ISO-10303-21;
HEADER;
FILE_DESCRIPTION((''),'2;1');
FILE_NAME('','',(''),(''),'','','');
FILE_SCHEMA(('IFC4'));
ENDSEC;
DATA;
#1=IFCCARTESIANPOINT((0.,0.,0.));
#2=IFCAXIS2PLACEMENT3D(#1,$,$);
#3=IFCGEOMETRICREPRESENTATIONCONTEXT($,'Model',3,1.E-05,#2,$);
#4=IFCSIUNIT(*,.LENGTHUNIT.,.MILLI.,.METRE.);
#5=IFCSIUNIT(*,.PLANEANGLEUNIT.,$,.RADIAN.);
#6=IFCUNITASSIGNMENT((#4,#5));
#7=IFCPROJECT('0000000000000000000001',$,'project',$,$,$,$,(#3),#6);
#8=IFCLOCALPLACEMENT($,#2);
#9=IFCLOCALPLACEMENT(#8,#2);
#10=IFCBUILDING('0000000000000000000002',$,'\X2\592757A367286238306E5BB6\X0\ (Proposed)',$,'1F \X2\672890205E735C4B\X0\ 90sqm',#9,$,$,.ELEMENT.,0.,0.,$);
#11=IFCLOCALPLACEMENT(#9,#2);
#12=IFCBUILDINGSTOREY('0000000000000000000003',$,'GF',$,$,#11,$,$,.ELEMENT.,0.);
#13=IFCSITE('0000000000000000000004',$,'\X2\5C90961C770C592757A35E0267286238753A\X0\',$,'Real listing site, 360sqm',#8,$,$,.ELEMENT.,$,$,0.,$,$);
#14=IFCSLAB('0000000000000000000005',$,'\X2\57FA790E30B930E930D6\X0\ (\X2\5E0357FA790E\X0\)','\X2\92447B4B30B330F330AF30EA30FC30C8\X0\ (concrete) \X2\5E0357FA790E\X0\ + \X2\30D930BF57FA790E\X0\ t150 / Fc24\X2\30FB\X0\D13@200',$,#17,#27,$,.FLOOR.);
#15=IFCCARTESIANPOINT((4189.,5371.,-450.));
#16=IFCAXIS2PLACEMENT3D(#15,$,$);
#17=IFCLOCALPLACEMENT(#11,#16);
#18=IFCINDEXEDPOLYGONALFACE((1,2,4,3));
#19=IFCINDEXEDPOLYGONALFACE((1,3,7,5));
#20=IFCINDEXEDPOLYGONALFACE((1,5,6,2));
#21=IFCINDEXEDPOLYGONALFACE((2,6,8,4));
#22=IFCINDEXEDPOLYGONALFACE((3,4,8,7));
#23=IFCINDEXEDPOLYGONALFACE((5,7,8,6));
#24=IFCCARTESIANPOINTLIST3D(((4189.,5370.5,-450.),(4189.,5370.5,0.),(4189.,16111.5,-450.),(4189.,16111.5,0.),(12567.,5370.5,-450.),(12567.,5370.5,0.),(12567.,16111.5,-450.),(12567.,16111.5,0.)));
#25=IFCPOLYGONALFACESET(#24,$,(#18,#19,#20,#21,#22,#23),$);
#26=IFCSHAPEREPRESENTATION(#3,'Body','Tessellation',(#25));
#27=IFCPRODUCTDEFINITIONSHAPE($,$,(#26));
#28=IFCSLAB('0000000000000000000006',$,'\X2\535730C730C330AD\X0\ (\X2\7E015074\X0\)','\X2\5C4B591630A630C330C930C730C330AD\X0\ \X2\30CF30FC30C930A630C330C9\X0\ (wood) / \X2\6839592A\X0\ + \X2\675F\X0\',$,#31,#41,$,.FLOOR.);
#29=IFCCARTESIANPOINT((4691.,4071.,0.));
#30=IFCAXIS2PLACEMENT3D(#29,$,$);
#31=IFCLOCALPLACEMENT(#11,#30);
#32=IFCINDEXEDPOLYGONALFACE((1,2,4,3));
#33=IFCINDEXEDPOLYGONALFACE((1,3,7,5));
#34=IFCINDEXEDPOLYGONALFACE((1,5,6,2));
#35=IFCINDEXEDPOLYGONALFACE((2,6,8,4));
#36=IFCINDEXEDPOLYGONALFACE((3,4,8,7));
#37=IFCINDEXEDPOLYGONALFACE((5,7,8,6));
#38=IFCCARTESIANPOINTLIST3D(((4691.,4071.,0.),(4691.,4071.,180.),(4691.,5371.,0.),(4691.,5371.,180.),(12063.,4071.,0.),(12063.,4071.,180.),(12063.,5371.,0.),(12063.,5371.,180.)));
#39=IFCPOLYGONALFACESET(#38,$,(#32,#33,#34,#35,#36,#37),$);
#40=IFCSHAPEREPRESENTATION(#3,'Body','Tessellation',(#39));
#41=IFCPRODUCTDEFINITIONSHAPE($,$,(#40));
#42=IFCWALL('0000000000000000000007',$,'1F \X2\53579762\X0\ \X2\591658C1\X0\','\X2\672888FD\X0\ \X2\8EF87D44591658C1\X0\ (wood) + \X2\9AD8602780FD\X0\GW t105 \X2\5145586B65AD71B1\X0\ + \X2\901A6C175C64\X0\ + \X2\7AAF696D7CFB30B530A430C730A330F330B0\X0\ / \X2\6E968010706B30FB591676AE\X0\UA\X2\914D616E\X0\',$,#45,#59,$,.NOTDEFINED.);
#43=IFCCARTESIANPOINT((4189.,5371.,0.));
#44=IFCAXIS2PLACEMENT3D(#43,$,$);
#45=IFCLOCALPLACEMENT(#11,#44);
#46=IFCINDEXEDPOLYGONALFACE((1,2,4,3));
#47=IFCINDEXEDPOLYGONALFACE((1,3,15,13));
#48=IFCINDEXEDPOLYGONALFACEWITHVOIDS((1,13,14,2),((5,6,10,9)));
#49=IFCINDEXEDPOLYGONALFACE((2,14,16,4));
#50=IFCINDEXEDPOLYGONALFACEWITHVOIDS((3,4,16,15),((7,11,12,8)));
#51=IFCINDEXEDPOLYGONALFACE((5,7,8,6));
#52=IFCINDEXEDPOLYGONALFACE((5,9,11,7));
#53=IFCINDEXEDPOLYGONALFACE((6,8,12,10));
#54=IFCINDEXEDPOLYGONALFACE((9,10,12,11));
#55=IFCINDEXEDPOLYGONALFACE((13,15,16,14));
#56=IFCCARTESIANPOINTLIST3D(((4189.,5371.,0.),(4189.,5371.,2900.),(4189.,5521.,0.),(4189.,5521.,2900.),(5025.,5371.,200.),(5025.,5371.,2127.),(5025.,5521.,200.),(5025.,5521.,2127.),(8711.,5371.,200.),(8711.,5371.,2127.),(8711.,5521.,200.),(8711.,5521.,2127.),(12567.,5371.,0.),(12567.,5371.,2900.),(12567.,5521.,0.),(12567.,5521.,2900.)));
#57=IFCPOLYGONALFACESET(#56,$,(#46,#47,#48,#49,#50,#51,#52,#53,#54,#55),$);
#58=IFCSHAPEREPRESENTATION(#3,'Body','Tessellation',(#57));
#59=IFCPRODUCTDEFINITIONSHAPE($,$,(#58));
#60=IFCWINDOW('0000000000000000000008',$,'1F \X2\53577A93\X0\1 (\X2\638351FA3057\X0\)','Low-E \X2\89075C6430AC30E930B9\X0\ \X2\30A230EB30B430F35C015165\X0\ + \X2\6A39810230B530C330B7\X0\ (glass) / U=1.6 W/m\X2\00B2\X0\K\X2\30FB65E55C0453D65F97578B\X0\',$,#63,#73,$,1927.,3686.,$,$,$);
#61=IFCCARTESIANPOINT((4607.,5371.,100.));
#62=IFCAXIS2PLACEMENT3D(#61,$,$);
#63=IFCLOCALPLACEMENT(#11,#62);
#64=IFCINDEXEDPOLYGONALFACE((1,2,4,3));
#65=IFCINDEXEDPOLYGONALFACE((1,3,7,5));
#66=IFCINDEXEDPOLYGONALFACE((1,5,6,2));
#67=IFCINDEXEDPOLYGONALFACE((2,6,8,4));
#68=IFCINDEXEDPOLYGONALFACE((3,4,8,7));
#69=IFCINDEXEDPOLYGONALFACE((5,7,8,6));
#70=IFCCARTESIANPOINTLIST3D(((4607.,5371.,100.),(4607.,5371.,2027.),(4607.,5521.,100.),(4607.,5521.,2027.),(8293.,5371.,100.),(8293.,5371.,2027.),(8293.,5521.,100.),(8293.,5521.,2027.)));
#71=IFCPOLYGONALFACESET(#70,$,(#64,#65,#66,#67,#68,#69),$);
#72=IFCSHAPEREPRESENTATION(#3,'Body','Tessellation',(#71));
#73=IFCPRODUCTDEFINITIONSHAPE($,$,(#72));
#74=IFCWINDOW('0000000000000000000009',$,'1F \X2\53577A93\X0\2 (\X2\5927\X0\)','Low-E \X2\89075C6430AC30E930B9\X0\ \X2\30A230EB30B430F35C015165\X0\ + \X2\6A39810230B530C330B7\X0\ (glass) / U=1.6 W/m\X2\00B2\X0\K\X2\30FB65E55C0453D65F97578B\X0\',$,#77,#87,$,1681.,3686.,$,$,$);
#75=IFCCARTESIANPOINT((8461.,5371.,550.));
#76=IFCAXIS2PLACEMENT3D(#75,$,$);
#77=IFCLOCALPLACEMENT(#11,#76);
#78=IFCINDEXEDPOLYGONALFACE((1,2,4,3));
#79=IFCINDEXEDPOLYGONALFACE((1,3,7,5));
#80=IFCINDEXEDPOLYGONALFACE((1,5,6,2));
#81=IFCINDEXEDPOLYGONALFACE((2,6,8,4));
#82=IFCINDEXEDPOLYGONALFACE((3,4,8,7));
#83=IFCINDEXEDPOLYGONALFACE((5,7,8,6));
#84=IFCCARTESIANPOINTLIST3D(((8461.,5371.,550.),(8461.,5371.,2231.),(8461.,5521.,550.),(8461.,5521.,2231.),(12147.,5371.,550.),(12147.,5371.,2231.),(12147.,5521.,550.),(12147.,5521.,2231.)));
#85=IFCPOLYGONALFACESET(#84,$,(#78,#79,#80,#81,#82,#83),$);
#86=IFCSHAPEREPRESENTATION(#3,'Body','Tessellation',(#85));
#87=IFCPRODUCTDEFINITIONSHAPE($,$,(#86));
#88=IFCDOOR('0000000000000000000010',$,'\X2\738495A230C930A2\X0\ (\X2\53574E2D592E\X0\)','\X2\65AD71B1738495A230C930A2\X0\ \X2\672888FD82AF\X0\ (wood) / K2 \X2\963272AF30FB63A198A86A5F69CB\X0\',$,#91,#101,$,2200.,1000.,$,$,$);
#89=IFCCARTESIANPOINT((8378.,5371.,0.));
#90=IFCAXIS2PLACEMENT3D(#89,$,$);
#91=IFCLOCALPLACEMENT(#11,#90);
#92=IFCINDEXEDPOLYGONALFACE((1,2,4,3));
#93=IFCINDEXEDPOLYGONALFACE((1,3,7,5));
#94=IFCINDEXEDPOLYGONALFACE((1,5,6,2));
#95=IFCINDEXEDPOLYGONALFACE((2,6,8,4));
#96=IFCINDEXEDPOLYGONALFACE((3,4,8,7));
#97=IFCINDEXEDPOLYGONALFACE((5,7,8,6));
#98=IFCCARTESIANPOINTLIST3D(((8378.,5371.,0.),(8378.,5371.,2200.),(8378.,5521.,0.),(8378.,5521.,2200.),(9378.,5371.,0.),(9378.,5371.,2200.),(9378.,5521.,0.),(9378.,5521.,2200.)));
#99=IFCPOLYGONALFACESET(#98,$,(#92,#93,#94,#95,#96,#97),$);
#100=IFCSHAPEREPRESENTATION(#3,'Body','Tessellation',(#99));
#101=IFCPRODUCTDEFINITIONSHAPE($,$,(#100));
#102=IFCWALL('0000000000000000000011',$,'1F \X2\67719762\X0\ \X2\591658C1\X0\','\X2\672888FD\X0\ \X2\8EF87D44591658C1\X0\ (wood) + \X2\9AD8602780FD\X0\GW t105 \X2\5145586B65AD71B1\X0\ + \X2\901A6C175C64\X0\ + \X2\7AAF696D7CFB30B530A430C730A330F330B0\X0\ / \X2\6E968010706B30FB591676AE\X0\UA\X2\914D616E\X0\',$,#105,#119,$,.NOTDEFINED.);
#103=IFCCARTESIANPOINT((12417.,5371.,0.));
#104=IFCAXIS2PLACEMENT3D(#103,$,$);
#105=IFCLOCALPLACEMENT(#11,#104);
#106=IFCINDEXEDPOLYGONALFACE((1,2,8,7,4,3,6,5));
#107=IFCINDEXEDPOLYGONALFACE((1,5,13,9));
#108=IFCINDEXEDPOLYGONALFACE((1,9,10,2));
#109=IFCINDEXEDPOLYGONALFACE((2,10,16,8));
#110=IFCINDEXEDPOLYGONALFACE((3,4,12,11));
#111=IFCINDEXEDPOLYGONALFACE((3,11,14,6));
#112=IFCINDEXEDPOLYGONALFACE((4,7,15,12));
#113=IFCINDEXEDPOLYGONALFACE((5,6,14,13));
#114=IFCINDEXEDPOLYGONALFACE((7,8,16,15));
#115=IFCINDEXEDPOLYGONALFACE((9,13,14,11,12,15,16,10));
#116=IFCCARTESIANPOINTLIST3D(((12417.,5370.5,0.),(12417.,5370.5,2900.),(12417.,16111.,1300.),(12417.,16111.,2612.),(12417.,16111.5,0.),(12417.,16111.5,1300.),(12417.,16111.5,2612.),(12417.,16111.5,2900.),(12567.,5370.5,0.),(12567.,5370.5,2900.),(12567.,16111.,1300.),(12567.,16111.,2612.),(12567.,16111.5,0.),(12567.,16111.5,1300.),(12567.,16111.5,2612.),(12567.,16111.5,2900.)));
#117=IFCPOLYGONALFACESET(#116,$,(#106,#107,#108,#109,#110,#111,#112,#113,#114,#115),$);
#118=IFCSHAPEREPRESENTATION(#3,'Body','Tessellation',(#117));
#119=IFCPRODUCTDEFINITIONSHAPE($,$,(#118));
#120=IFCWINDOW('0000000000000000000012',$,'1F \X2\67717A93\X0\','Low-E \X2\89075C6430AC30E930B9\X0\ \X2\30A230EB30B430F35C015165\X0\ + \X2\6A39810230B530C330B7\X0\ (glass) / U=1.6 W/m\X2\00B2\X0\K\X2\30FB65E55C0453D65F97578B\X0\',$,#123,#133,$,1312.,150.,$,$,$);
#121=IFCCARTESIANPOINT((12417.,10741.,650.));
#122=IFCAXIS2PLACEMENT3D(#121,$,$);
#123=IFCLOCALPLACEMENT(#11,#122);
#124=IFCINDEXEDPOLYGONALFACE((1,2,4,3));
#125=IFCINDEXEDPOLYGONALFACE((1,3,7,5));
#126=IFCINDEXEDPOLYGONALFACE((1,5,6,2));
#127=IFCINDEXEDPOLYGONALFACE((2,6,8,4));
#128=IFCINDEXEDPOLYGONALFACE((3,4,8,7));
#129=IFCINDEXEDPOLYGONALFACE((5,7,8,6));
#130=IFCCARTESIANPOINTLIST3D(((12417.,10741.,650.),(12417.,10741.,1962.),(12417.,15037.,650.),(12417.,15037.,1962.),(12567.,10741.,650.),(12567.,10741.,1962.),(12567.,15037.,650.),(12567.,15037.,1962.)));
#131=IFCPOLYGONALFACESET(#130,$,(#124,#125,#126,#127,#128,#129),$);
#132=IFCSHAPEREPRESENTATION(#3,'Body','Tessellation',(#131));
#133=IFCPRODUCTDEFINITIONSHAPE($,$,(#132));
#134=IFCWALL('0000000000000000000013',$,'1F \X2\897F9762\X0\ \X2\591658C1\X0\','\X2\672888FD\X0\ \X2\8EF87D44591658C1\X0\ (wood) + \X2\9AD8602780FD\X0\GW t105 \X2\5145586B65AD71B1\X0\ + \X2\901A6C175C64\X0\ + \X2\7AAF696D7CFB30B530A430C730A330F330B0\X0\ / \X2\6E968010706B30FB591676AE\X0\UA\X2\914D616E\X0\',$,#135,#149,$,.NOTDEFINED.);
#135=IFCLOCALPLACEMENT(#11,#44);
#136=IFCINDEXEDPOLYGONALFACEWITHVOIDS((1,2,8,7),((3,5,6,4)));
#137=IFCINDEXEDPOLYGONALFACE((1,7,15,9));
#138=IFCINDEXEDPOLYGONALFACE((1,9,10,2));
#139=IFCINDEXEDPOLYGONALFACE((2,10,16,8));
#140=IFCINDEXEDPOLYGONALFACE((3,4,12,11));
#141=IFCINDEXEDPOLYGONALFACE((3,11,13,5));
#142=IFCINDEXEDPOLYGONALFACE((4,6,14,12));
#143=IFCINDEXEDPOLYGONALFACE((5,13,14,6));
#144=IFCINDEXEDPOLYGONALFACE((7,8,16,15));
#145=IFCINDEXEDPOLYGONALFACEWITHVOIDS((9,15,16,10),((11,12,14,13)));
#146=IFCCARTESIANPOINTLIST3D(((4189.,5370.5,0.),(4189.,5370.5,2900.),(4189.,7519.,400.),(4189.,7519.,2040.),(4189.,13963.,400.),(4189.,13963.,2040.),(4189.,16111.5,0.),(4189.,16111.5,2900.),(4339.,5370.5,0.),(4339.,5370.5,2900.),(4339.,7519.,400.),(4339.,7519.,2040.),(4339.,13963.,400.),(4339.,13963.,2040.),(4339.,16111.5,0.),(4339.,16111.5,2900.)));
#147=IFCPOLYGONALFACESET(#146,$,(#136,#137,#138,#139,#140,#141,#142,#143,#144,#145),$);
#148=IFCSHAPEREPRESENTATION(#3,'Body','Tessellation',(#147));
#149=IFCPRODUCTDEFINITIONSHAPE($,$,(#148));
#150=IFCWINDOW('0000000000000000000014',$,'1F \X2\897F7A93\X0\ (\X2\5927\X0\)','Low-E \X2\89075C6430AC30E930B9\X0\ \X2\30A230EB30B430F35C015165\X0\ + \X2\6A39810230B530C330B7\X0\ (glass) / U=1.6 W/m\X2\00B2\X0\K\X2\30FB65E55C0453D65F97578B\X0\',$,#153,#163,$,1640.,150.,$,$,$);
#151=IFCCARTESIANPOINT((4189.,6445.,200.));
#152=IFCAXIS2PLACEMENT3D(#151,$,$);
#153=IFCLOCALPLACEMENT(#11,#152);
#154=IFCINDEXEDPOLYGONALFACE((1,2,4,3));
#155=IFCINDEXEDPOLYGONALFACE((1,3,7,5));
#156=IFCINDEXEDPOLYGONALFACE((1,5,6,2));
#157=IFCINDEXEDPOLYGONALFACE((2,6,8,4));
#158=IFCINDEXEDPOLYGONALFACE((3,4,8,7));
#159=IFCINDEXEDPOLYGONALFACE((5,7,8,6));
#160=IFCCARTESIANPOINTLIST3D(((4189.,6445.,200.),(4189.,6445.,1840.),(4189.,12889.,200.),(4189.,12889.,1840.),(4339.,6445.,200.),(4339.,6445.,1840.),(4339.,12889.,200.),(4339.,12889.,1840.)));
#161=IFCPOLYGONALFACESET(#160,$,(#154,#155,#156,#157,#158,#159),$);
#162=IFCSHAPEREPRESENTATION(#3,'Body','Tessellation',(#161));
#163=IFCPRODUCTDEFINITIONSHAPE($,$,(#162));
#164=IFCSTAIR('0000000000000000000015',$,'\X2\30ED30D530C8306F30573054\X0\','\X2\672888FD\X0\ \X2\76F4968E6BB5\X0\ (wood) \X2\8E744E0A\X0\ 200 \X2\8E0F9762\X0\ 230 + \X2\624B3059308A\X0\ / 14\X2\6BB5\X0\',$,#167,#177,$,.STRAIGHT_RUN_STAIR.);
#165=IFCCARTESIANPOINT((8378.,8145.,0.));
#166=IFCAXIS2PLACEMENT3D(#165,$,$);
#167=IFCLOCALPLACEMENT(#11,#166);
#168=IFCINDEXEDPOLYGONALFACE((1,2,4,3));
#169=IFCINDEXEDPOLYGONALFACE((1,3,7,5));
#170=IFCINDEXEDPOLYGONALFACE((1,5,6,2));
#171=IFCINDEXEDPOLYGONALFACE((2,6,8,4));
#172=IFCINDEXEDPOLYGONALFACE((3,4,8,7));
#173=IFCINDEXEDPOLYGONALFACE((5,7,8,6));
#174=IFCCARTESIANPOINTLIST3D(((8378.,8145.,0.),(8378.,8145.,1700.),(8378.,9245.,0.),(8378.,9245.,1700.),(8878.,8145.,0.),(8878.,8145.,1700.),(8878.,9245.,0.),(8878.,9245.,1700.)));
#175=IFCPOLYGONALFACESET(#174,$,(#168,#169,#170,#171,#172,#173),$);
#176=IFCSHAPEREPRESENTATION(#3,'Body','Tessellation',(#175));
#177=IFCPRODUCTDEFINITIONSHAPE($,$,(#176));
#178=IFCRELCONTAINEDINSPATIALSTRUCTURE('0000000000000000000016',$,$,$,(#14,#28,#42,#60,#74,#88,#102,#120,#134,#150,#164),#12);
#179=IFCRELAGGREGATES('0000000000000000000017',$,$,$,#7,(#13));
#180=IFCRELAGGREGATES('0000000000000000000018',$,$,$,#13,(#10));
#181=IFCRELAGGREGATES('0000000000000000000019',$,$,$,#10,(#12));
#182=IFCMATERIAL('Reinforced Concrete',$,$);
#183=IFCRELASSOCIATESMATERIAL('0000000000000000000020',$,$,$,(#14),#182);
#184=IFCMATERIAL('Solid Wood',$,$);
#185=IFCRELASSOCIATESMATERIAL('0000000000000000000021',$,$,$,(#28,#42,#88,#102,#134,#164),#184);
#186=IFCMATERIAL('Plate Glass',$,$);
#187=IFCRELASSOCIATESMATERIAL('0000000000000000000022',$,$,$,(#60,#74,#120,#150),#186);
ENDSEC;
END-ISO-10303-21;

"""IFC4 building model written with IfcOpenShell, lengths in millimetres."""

from ifc_helpers import new_model, si_unit, frame, frame_2d, origin, place, context, project, spatial, rectangle, extrude, material, element, fill, save


model = new_model("IFC4")

# Units and contexts
model_context = context("Model", 3, precision=1e-05, world=origin())
ifc_project = project(units=[si_unit("LENGTHUNIT", "METRE", prefix="MILLI"), si_unit("PLANEANGLEUNIT", "RADIAN")], contexts=[model_context])

# Site, building, storey
site_placement = place(None, origin())
site = spatial("IfcSite", under=ifc_project, at=site_placement, Name="岐阜県大垣市木戸町", ObjectType="Real listing site, 360sqm", CompositionType="ELEMENT", RefElevation=0.0)
building_placement = place(site_placement, origin())
building = spatial("IfcBuilding", under=site, at=building_placement, Name="大垣木戸の家 (Proposed)", ObjectType="1F 木造平屋 90sqm", CompositionType="ELEMENT", ElevationOfRefHeight=0.0, ElevationOfTerrain=0.0)
storey_placement = place(building_placement, origin())
storey = spatial("IfcBuildingStorey", under=building, at=storey_placement, Name="GF", CompositionType="ELEMENT", Elevation=0.0)

# Slabs
ifc_material_1 = material(Name="Reinforced Concrete")
slab_1_placement = place(storey_placement, frame((4189.0, 5371.0, -450.0)))
element("IfcSlab", 1, at=slab_1_placement, inside=storey, material=ifc_material_1, Name="基礎スラブ (布基礎)", Description="鉄筋コンクリート (concrete) 布基礎 + ベタ基礎 t150 / Fc24・D13@200", PredefinedType="FLOOR", context=model_context, shape_type="SweptSolid", body=[
    extrude(rectangle(XDim=8378.0, YDim=10741.0, at=frame_2d((4189.0, 5370.0))), frame((4189.0, 5371.0, -450.0)), (0.0, 0.0, 1.0), 450.0),
])
ifc_material_2 = material(Name="Solid Wood")
slab_2_placement = place(storey_placement, frame((4691.0, 4071.0, 0.0)))
element("IfcSlab", 2, at=slab_2_placement, inside=storey, material=ifc_material_2, Name="南デッキ (縁側)", Description="屋外ウッドデッキ ハードウッド (wood) / 根太 + 束", PredefinedType="FLOOR", context=model_context, shape_type="SweptSolid", body=[
    extrude(rectangle(XDim=7372.0, YDim=1300.0, at=frame_2d((3686.0, 650.0))), frame((4691.0, 4071.0, 0.0)), (0.0, 0.0, 1.0), 180.0),
])

# Wall, openings, windows, door
wall_1_placement = place(storey_placement, frame((4189.0, 5371.0, 0.0)))
wall_1 = element("IfcWall", 3, at=wall_1_placement, inside=storey, material=ifc_material_2, Name="1F 南面 外壁", Description="木製 軸組外壁 (wood) + 高性能GW t105 充填断熱 + 通気層 + 窯業系サイディング / 準耐火・外皮UA配慮", PredefinedType="NOTDEFINED", context=model_context, shape_type="SweptSolid", body=[
    extrude(rectangle(XDim=8378.0, YDim=150.0, at=frame_2d((4189.0, 75.0))), frame((4189.0, 5371.0, 0.0)), (0.0, 0.0, 1.0), 2900.0),
])
opening_1_placement = place(storey_placement, frame((4607.0, 5371.0, 100.0)))
opening_1 = element("IfcOpeningElement", 4, at=opening_1_placement, cuts=wall_1, PredefinedType="NOTDEFINED", context=model_context, shape_type="SweptSolid", body=[
    extrude(rectangle(XDim=3686.0, YDim=150.0, at=frame_2d((1843.0, 75.0))), frame((4607.0, 5371.0, 100.0)), (0.0, 0.0, 1.0), 1927.0),
])
opening_2_placement = place(storey_placement, frame((8461.0, 5371.0, 550.0)))
opening_2 = element("IfcOpeningElement", 5, at=opening_2_placement, cuts=wall_1, PredefinedType="NOTDEFINED", context=model_context, shape_type="SweptSolid", body=[
    extrude(rectangle(XDim=3686.0, YDim=150.0, at=frame_2d((1843.0, 75.0))), frame((8461.0, 5371.0, 550.0)), (0.0, 0.0, 1.0), 1681.0),
])
opening_3_placement = place(storey_placement, frame((8378.0, 5371.0, 0.0)))
opening_3 = element("IfcOpeningElement", 6, at=opening_3_placement, cuts=wall_1, PredefinedType="NOTDEFINED", context=model_context, shape_type="SweptSolid", body=[
    extrude(rectangle(XDim=1000.0, YDim=150.0, at=frame_2d((500.0, 75.0))), frame((8378.0, 5371.0, 0.0)), (0.0, 0.0, 1.0), 2200.0),
])
ifc_material_3 = material(Name="Plate Glass")
window_1_placement = place(storey_placement, frame((4607.0, 5371.0, 100.0)))
window_1 = element("IfcWindow", 7, at=window_1_placement, inside=storey, material=ifc_material_3, Name="1F 南窓1 (掃出し)", Description="Low-E 複層ガラス アルゴン封入 + 樹脂サッシ (glass) / U=1.6 W/m²K・日射取得型", OverallHeight=1927.0, OverallWidth=3686.0, context=model_context, shape_type="SweptSolid", body=[
    extrude(rectangle(XDim=3686.0, YDim=150.0, at=frame_2d((1843.0, 75.0))), frame((4607.0, 5371.0, 100.0)), (0.0, 0.0, 1.0), 1927.0),
])
fill(opening_1, window_1)
window_2_placement = place(storey_placement, frame((8461.0, 5371.0, 550.0)))
window_2 = element("IfcWindow", 8, at=window_2_placement, inside=storey, material=ifc_material_3, Name="1F 南窓2 (大)", Description="Low-E 複層ガラス アルゴン封入 + 樹脂サッシ (glass) / U=1.6 W/m²K・日射取得型", OverallHeight=1681.0, OverallWidth=3686.0, context=model_context, shape_type="SweptSolid", body=[
    extrude(rectangle(XDim=3686.0, YDim=150.0, at=frame_2d((1843.0, 75.0))), frame((8461.0, 5371.0, 550.0)), (0.0, 0.0, 1.0), 1681.0),
])
fill(opening_2, window_2)
door_placement = place(storey_placement, frame((8378.0, 5371.0, 0.0)))
door = element("IfcDoor", 9, at=door_placement, inside=storey, material=ifc_material_2, Name="玄関ドア (南中央)", Description="断熱玄関ドア 木製芯 (wood) / K2 防犯・採風機構", OverallHeight=2200.0, OverallWidth=1000.0, context=model_context, shape_type="SweptSolid", body=[
    extrude(rectangle(XDim=1000.0, YDim=150.0, at=frame_2d((500.0, 75.0))), frame((8378.0, 5371.0, 0.0)), (0.0, 0.0, 1.0), 2200.0),
])
fill(opening_3, door)

# Walls, openings, windows
wall_2_placement = place(storey_placement, frame((12417.0, 5371.0, 0.0)))
wall_2 = element("IfcWall", 10, at=wall_2_placement, inside=storey, material=ifc_material_2, Name="1F 東面 外壁", Description="木製 軸組外壁 (wood) + 高性能GW t105 充填断熱 + 通気層 + 窯業系サイディング / 準耐火・外皮UA配慮", PredefinedType="NOTDEFINED", context=model_context, shape_type="SweptSolid", body=[
    extrude(rectangle(XDim=150.0, YDim=10741.0, at=frame_2d((75.0, 5370.0))), frame((12417.0, 5371.0, 0.0)), (0.0, 0.0, 1.0), 2900.0),
])
opening_4_placement = place(storey_placement, frame((12417.0, 10741.0, 650.0)))
opening_4 = element("IfcOpeningElement", 11, at=opening_4_placement, cuts=wall_2, PredefinedType="NOTDEFINED", context=model_context, shape_type="SweptSolid", body=[
    extrude(rectangle(XDim=150.0, YDim=4296.0, at=frame_2d((75.0, 2148.0))), frame((12417.0, 10741.0, 650.0)), (0.0, 0.0, 1.0), 1312.0),
])
window_3_placement = place(storey_placement, frame((12417.0, 10741.0, 650.0)))
window_3 = element("IfcWindow", 12, at=window_3_placement, inside=storey, material=ifc_material_3, Name="1F 東窓", Description="Low-E 複層ガラス アルゴン封入 + 樹脂サッシ (glass) / U=1.6 W/m²K・日射取得型", OverallHeight=1312.0, OverallWidth=150.0, context=model_context, shape_type="SweptSolid", body=[
    extrude(rectangle(XDim=150.0, YDim=4296.0, at=frame_2d((75.0, 2148.0))), frame((12417.0, 10741.0, 650.0)), (0.0, 0.0, 1.0), 1312.0),
])
fill(opening_4, window_3)
wall_3_placement = place(storey_placement, frame((4189.0, 5371.0, 0.0)))
wall_3 = element("IfcWall", 13, at=wall_3_placement, inside=storey, material=ifc_material_2, Name="1F 西面 外壁", Description="木製 軸組外壁 (wood) + 高性能GW t105 充填断熱 + 通気層 + 窯業系サイディング / 準耐火・外皮UA配慮", PredefinedType="NOTDEFINED", context=model_context, shape_type="SweptSolid", body=[
    extrude(rectangle(XDim=150.0, YDim=10741.0, at=frame_2d((75.0, 5370.0))), frame((4189.0, 5371.0, 0.0)), (0.0, 0.0, 1.0), 2900.0),
])
opening_5_placement = place(storey_placement, frame((4189.0, 6445.0, 200.0)))
opening_5 = element("IfcOpeningElement", 14, at=opening_5_placement, cuts=wall_3, PredefinedType="NOTDEFINED", context=model_context, shape_type="SweptSolid", body=[
    extrude(rectangle(XDim=150.0, YDim=6444.0, at=frame_2d((75.0, 3222.0))), frame((4189.0, 6445.0, 200.0)), (0.0, 0.0, 1.0), 1640.0),
])
window_4_placement = place(storey_placement, frame((4189.0, 6445.0, 200.0)))
window_4 = element("IfcWindow", 15, at=window_4_placement, inside=storey, material=ifc_material_3, Name="1F 西窓 (大)", Description="Low-E 複層ガラス アルゴン封入 + 樹脂サッシ (glass) / U=1.6 W/m²K・日射取得型", OverallHeight=1640.0, OverallWidth=150.0, context=model_context, shape_type="SweptSolid", body=[
    extrude(rectangle(XDim=150.0, YDim=6444.0, at=frame_2d((75.0, 3222.0))), frame((4189.0, 6445.0, 200.0)), (0.0, 0.0, 1.0), 1640.0),
])
fill(opening_5, window_4)

# Stair
stair_placement = place(storey_placement, frame((8378.0, 8145.0, 0.0)))
element("IfcStair", 16, at=stair_placement, inside=storey, material=ifc_material_2, Name="ロフトはしご", Description="木製 直階段 (wood) 蹴上 200 踏面 230 + 手すり / 14段", PredefinedType="STRAIGHT_RUN_STAIR", context=model_context, shape_type="SweptSolid", body=[
    extrude(rectangle(XDim=500.0, YDim=1100.0, at=frame_2d((250.0, 550.0))), frame((8378.0, 8145.0, 0.0)), (0.0, 0.0, 1.0), 1700.0),
])

save(model, "model.ifc")
